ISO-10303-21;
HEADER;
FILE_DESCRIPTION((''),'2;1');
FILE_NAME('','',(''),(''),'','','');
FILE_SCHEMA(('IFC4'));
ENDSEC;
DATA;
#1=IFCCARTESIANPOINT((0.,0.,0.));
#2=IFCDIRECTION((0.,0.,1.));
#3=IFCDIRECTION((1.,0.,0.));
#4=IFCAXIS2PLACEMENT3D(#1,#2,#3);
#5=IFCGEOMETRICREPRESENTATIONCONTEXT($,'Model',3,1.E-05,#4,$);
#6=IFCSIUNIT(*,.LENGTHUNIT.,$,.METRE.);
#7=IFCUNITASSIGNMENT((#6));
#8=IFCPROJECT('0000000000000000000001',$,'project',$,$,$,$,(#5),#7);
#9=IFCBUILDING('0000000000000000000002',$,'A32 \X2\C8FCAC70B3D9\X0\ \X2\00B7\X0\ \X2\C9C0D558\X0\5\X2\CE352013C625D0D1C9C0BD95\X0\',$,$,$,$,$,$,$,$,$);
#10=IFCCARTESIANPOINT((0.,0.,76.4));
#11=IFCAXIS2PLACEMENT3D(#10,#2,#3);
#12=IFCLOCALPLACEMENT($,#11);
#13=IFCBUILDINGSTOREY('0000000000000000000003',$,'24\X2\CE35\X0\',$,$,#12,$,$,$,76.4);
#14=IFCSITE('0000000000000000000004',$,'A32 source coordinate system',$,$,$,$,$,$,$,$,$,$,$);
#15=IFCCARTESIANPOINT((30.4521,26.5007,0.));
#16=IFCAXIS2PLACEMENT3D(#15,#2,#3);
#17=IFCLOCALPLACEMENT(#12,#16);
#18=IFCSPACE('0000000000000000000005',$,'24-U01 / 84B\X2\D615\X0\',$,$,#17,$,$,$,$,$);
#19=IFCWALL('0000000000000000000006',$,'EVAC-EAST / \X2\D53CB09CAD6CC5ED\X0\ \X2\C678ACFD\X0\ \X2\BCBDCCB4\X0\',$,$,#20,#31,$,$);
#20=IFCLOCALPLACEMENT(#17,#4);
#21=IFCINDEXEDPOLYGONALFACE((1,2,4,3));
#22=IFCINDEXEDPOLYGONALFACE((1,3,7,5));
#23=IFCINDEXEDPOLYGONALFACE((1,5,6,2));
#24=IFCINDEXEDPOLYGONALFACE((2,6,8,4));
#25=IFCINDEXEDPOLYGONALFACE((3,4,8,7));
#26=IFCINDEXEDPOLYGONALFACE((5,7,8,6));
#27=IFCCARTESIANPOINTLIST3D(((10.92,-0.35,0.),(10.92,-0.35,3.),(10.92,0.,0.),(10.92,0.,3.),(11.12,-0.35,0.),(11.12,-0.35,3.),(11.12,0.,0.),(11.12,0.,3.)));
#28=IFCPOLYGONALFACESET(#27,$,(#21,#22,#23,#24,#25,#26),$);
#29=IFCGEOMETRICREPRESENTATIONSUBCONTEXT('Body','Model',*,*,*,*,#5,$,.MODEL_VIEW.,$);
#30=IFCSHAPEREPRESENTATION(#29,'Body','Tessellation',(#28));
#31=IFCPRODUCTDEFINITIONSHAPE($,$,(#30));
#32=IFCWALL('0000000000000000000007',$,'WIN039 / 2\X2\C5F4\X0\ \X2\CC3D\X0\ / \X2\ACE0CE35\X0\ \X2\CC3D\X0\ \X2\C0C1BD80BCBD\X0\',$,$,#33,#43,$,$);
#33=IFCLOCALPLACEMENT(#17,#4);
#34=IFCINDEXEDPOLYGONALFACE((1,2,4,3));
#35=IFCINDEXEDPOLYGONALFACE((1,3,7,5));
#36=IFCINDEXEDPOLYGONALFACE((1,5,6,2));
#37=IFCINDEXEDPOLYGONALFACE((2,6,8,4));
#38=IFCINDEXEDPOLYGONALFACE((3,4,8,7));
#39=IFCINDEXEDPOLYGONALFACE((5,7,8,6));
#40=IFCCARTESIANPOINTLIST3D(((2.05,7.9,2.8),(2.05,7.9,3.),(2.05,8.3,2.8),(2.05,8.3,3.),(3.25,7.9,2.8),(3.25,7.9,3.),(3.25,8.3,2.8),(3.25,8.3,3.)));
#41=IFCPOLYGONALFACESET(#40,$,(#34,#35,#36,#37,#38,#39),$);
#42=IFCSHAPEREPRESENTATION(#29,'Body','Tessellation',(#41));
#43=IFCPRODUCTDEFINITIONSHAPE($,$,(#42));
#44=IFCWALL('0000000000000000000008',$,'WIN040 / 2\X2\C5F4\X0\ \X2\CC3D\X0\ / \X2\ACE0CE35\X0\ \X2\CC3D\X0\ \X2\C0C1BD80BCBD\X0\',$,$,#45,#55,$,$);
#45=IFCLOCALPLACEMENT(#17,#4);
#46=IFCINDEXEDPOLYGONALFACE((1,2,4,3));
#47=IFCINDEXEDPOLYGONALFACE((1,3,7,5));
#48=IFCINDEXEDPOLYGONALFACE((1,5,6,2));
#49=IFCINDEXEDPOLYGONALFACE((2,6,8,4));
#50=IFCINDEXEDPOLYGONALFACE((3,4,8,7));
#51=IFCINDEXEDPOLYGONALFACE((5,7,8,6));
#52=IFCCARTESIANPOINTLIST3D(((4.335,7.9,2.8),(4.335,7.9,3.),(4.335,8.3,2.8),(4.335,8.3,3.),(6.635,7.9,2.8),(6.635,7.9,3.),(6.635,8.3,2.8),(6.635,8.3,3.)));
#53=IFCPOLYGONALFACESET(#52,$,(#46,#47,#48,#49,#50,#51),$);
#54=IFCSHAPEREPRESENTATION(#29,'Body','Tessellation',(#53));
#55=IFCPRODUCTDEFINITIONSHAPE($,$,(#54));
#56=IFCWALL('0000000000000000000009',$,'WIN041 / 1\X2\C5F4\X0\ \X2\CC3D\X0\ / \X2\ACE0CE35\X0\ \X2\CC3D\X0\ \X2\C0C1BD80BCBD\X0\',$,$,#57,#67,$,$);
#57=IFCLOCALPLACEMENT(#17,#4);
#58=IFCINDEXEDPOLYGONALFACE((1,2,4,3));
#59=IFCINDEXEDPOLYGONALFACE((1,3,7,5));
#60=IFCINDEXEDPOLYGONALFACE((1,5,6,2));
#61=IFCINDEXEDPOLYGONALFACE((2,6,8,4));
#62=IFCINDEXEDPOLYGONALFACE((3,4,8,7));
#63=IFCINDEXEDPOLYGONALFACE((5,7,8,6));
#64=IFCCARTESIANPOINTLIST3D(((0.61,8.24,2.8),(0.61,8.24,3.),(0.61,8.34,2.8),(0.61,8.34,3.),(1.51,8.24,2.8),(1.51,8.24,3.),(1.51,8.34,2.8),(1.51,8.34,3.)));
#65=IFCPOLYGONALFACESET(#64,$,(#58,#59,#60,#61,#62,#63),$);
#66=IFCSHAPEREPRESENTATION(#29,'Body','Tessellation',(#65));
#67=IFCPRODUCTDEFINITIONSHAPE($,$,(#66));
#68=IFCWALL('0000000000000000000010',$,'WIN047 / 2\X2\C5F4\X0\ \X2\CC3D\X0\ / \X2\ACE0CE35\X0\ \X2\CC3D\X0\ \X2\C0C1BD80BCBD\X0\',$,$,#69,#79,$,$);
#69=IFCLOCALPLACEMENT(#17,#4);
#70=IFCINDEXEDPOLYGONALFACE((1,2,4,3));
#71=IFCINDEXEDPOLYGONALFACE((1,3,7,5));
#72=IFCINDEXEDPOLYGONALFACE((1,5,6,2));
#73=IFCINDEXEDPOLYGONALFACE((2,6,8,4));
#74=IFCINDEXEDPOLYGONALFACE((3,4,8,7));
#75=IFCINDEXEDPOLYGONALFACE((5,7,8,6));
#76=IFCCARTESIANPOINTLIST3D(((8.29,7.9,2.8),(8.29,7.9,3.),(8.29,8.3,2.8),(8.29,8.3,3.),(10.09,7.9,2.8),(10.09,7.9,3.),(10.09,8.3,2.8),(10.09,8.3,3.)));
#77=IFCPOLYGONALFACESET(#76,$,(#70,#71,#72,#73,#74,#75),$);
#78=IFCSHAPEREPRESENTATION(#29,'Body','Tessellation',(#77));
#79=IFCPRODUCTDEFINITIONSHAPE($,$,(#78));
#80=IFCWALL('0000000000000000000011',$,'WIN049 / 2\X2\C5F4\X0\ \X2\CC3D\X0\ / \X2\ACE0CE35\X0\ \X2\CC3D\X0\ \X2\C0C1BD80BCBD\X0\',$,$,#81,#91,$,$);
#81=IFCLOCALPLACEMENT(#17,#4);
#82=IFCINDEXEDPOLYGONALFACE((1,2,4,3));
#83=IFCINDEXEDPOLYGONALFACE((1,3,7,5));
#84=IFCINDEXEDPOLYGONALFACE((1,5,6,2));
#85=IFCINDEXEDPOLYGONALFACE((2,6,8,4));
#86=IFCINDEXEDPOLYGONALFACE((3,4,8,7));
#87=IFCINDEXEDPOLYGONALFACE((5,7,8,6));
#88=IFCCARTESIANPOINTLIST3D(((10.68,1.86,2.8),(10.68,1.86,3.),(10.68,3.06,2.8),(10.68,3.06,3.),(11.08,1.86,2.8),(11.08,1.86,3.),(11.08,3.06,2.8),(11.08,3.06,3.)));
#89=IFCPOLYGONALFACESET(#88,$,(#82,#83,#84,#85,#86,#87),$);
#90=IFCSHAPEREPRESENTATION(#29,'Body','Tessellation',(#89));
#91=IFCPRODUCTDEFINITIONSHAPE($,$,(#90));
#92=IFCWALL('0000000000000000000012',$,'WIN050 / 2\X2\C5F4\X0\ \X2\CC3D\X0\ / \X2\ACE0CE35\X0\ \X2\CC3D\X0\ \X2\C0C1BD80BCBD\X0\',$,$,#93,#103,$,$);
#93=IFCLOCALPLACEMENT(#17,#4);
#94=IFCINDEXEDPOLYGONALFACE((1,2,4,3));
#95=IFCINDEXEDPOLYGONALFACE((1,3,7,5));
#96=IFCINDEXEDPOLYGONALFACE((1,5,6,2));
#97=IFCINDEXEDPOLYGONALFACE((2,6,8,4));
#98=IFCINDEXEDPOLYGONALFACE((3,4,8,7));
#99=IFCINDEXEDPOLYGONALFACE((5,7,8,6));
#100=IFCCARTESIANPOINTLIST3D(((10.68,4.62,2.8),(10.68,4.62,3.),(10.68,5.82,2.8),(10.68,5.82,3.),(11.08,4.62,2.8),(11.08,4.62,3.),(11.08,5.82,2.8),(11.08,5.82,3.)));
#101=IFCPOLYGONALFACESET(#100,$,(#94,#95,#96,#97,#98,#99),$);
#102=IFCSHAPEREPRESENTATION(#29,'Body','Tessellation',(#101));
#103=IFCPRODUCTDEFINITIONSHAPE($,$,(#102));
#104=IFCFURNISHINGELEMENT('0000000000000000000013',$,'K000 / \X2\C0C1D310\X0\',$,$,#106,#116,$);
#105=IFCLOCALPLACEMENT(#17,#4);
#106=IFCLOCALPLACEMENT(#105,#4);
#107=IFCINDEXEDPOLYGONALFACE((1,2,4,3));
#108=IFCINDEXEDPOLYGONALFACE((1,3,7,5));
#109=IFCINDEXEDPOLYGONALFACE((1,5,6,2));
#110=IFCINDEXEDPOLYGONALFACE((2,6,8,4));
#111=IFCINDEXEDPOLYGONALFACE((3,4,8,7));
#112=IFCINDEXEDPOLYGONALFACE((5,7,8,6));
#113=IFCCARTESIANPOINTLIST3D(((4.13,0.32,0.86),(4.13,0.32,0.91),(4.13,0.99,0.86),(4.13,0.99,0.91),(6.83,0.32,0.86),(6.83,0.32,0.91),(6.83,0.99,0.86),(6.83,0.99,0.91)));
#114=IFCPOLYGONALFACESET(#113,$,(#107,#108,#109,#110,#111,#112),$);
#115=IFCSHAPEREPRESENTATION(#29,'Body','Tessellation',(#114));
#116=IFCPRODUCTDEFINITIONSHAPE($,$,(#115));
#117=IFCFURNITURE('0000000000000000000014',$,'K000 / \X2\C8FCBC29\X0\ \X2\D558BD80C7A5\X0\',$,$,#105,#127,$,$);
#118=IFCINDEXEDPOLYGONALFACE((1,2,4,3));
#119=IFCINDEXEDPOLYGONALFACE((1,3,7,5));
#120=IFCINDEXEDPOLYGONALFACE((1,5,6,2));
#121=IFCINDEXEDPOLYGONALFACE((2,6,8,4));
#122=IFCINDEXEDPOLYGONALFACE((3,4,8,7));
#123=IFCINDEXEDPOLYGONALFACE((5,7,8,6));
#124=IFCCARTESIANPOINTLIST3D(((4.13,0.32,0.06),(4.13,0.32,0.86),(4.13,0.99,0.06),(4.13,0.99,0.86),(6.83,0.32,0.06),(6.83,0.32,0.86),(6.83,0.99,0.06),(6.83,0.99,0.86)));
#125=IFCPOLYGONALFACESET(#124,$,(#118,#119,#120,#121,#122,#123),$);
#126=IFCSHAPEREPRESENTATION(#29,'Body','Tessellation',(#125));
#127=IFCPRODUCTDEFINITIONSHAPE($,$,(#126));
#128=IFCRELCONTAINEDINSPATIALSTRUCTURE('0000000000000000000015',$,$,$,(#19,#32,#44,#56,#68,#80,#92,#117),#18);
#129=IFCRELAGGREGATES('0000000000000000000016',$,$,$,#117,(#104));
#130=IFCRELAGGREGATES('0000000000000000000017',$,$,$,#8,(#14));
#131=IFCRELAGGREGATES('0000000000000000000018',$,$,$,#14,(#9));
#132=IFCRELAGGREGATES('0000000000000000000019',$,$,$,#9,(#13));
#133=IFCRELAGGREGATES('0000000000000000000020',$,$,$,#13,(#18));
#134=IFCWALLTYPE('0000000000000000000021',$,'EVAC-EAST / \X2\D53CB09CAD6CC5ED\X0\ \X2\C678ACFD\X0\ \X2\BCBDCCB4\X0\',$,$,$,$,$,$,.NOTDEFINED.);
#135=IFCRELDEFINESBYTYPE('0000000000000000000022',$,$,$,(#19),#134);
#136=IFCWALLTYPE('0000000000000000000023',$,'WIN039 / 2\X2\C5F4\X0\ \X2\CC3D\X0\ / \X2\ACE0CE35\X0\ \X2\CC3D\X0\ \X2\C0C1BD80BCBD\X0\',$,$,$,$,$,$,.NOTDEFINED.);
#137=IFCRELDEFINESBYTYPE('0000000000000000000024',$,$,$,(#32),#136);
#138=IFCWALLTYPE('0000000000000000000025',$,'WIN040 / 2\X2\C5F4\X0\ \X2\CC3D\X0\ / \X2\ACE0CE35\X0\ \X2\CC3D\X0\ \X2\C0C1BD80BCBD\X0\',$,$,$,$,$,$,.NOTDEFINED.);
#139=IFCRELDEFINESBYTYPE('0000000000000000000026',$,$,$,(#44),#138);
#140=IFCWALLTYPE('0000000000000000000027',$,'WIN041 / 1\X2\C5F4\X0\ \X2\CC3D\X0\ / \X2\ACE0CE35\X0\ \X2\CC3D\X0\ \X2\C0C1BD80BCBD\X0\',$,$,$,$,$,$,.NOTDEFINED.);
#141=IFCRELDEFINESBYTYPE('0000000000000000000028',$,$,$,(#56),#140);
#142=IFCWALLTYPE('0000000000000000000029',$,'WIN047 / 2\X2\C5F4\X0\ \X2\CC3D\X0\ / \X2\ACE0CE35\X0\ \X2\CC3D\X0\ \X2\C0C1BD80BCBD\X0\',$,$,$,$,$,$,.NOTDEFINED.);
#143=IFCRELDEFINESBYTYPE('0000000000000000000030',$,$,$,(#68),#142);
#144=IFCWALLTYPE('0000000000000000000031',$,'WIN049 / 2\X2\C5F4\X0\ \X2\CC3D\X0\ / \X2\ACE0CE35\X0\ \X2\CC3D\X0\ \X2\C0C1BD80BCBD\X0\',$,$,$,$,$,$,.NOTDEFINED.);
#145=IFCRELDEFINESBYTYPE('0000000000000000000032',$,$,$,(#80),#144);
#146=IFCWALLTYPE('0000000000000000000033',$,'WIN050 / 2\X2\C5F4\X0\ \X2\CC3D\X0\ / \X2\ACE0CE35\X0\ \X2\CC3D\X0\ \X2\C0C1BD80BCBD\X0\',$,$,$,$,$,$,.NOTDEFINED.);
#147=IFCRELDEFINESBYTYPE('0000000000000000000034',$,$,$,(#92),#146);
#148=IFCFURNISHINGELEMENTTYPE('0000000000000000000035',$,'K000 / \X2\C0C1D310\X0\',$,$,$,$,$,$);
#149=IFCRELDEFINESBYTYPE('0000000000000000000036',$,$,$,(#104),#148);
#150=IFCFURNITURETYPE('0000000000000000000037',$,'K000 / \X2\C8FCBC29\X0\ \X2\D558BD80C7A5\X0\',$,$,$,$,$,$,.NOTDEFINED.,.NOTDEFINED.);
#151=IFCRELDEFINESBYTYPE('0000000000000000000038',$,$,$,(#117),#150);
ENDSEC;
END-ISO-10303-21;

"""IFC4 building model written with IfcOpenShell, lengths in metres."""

from ifc_helpers import new_model, si_unit, frame, origin, origin_with_axes, place, context, subcontext, project, spatial, polyline, outline, extrude, source, transform, mapped, type_object, type_shapes, element, aggregate, save


model = new_model("IFC4")

# Units and contexts
model_context = context("Model", 3, precision=1e-05, world=origin_with_axes())
body_context = subcontext(model_context, "Body", "Model", "MODEL_VIEW")
ifc_project = project(units=[si_unit("LENGTHUNIT", "METRE")], contexts=[model_context])

# Site, building, storey, space
site = spatial("IfcSite", under=ifc_project, Name="A32 source coordinate system")
building = spatial("IfcBuilding", under=site, Name="A32 주거동 · 지하5층–옥탑지붕")
storey_placement = place(None, frame((0.0, 0.0, 76.4), z_axis=(0.0, 0.0, 1.0), x_axis=(1.0, 0.0, 0.0)))
storey = spatial("IfcBuildingStorey", under=building, at=storey_placement, Name="24층", Elevation=76.4)
space_placement = place(storey_placement, frame((30.4521, 26.5007, 0.0), z_axis=(0.0, 0.0, 1.0), x_axis=(1.0, 0.0, 0.0)))
space = spatial("IfcSpace", under=storey, at=space_placement, Name="24-U01 / 84B형")

# Walls
wall_type_1 = type_object("IfcWallType", Name="EVAC-EAST / 피난구역 외곽 벽체", PredefinedType="NOTDEFINED")
shared_shape_1 = source(origin(), body_context, "Body", "SweptSolid", [
    extrude(outline(polyline([(10.92, 0.0), (11.12, 0.0), (11.12, -0.35), (10.92, -0.35), (10.92, 0.0)])), origin(), (0.0, 0.0, 1.0), 3.0),
])
type_shapes(wall_type_1, [shared_shape_1])
wall_1_placement = place(space_placement, origin_with_axes())
element("IfcWall", 1, at=wall_1_placement, inside=space, type_object=wall_type_1, Name="EVAC-EAST / 피난구역 외곽 벽체", context=body_context, shape_type="MappedRepresentation", body=[
    mapped(shared_shape_1, transform((0.0, 0.0, 0.0), scale=1.0)),
])
wall_type_2 = type_object("IfcWallType", Name="WIN039 / 2열 창 / 고층 창 상부벽", PredefinedType="NOTDEFINED")
shared_shape_2 = source(origin(), body_context, "Body", "SweptSolid", [
    extrude(outline(polyline([(3.25, 7.9), (3.25, 8.3), (2.05, 8.3), (2.05, 7.9), (3.25, 7.9)])), frame((0.0, 0.0, 2.8)), (0.0, 0.0, 1.0), 0.2),
])
type_shapes(wall_type_2, [shared_shape_2])
wall_2_placement = place(space_placement, origin_with_axes())
element("IfcWall", 2, at=wall_2_placement, inside=space, type_object=wall_type_2, Name="WIN039 / 2열 창 / 고층 창 상부벽", context=body_context, shape_type="MappedRepresentation", body=[
    mapped(shared_shape_2, transform((0.0, 0.0, 0.0), scale=1.0)),
])
wall_type_3 = type_object("IfcWallType", Name="WIN040 / 2열 창 / 고층 창 상부벽", PredefinedType="NOTDEFINED")
shared_shape_3 = source(origin(), body_context, "Body", "SweptSolid", [
    extrude(outline(polyline([(6.635, 7.9), (6.635, 8.3), (4.335, 8.3), (4.335, 7.9), (6.635, 7.9)])), frame((0.0, 0.0, 2.8)), (0.0, 0.0, 1.0), 0.2),
])
type_shapes(wall_type_3, [shared_shape_3])
wall_3_placement = place(space_placement, origin_with_axes())
element("IfcWall", 3, at=wall_3_placement, inside=space, type_object=wall_type_3, Name="WIN040 / 2열 창 / 고층 창 상부벽", context=body_context, shape_type="MappedRepresentation", body=[
    mapped(shared_shape_3, transform((0.0, 0.0, 0.0), scale=1.0)),
])
wall_type_4 = type_object("IfcWallType", Name="WIN041 / 1열 창 / 고층 창 상부벽", PredefinedType="NOTDEFINED")
shared_shape_4 = source(origin(), body_context, "Body", "SweptSolid", [
    extrude(outline(polyline([(1.51, 8.24), (1.51, 8.34), (0.61, 8.34), (0.61, 8.24), (1.51, 8.24)])), frame((0.0, 0.0, 2.8)), (0.0, 0.0, 1.0), 0.2),
])
type_shapes(wall_type_4, [shared_shape_4])
wall_4_placement = place(space_placement, origin_with_axes())
element("IfcWall", 4, at=wall_4_placement, inside=space, type_object=wall_type_4, Name="WIN041 / 1열 창 / 고층 창 상부벽", context=body_context, shape_type="MappedRepresentation", body=[
    mapped(shared_shape_4, transform((0.0, 0.0, 0.0), scale=1.0)),
])
wall_type_5 = type_object("IfcWallType", Name="WIN047 / 2열 창 / 고층 창 상부벽", PredefinedType="NOTDEFINED")
shared_shape_5 = source(origin(), body_context, "Body", "SweptSolid", [
    extrude(outline(polyline([(10.09, 7.9), (10.09, 8.3), (8.29, 8.3), (8.29, 7.9), (10.09, 7.9)])), frame((0.0, 0.0, 2.8)), (0.0, 0.0, 1.0), 0.2),
])
type_shapes(wall_type_5, [shared_shape_5])
wall_5_placement = place(space_placement, origin_with_axes())
element("IfcWall", 5, at=wall_5_placement, inside=space, type_object=wall_type_5, Name="WIN047 / 2열 창 / 고층 창 상부벽", context=body_context, shape_type="MappedRepresentation", body=[
    mapped(shared_shape_5, transform((0.0, 0.0, 0.0), scale=1.0)),
])
wall_type_6 = type_object("IfcWallType", Name="WIN049 / 2열 창 / 고층 창 상부벽", PredefinedType="NOTDEFINED")
shared_shape_6 = source(origin(), body_context, "Body", "SweptSolid", [
    extrude(outline(polyline([(11.08, 1.86), (11.08, 3.06), (10.68, 3.06), (10.68, 1.86), (11.08, 1.86)])), frame((0.0, 0.0, 2.8)), (0.0, 0.0, 1.0), 0.2),
])
type_shapes(wall_type_6, [shared_shape_6])
wall_6_placement = place(space_placement, origin_with_axes())
element("IfcWall", 6, at=wall_6_placement, inside=space, type_object=wall_type_6, Name="WIN049 / 2열 창 / 고층 창 상부벽", context=body_context, shape_type="MappedRepresentation", body=[
    mapped(shared_shape_6, transform((0.0, 0.0, 0.0), scale=1.0)),
])
wall_type_7 = type_object("IfcWallType", Name="WIN050 / 2열 창 / 고층 창 상부벽", PredefinedType="NOTDEFINED")
shared_shape_7 = source(origin(), body_context, "Body", "SweptSolid", [
    extrude(outline(polyline([(11.08, 4.62), (11.08, 5.82), (10.68, 5.82), (10.68, 4.62), (11.08, 4.62)])), frame((0.0, 0.0, 2.8)), (0.0, 0.0, 1.0), 0.2),
])
type_shapes(wall_type_7, [shared_shape_7])
wall_7_placement = place(space_placement, origin_with_axes())
element("IfcWall", 7, at=wall_7_placement, inside=space, type_object=wall_type_7, Name="WIN050 / 2열 창 / 고층 창 상부벽", context=body_context, shape_type="MappedRepresentation", body=[
    mapped(shared_shape_7, transform((0.0, 0.0, 0.0), scale=1.0)),
])

# Furnishing element
furnishing_element_type = type_object("IfcFurnishingElementType", Name="K000 / 상판")
shared_shape_8 = source(origin(), body_context, "Body", "SweptSolid", [
    extrude(outline(polyline([(4.13, 0.32), (4.13, 0.99), (6.83, 0.99), (6.83, 0.32), (4.13, 0.32)])), frame((0.0, 0.0, 0.86)), (0.0, 0.0, 1.0), 0.05),
])
type_shapes(furnishing_element_type, [shared_shape_8])
furniture_placement = place(space_placement, origin_with_axes())
furnishing_placement = place(furniture_placement, origin_with_axes())
furnishing = element("IfcFurnishingElement", 8, at=furnishing_placement, type_object=furnishing_element_type, Name="K000 / 상판", context=body_context, shape_type="MappedRepresentation", body=[
    mapped(shared_shape_8, transform((0.0, 0.0, 0.0), scale=1.0)),
])

# Furniture
furniture_type = type_object("IfcFurnitureType", Name="K000 / 주방 하부장", AssemblyPlace="NOTDEFINED", PredefinedType="NOTDEFINED")
shared_shape_9 = source(origin(), body_context, "Body", "SweptSolid", [
    extrude(outline(polyline([(6.83, 0.32), (4.13, 0.32), (4.13, 0.99), (6.83, 0.99), (6.83, 0.32)])), frame((0.0, 0.0, 0.06)), (0.0, 0.0, 1.0), 0.8),
])
type_shapes(furniture_type, [shared_shape_9])
furniture = element("IfcFurniture", 9, at=furniture_placement, inside=space, type_object=furniture_type, Name="K000 / 주방 하부장", context=body_context, shape_type="MappedRepresentation", body=[
    mapped(shared_shape_9, transform((0.0, 0.0, 0.0), scale=1.0)),
])
aggregate(furniture, [furnishing])

save(model, "model.ifc")
